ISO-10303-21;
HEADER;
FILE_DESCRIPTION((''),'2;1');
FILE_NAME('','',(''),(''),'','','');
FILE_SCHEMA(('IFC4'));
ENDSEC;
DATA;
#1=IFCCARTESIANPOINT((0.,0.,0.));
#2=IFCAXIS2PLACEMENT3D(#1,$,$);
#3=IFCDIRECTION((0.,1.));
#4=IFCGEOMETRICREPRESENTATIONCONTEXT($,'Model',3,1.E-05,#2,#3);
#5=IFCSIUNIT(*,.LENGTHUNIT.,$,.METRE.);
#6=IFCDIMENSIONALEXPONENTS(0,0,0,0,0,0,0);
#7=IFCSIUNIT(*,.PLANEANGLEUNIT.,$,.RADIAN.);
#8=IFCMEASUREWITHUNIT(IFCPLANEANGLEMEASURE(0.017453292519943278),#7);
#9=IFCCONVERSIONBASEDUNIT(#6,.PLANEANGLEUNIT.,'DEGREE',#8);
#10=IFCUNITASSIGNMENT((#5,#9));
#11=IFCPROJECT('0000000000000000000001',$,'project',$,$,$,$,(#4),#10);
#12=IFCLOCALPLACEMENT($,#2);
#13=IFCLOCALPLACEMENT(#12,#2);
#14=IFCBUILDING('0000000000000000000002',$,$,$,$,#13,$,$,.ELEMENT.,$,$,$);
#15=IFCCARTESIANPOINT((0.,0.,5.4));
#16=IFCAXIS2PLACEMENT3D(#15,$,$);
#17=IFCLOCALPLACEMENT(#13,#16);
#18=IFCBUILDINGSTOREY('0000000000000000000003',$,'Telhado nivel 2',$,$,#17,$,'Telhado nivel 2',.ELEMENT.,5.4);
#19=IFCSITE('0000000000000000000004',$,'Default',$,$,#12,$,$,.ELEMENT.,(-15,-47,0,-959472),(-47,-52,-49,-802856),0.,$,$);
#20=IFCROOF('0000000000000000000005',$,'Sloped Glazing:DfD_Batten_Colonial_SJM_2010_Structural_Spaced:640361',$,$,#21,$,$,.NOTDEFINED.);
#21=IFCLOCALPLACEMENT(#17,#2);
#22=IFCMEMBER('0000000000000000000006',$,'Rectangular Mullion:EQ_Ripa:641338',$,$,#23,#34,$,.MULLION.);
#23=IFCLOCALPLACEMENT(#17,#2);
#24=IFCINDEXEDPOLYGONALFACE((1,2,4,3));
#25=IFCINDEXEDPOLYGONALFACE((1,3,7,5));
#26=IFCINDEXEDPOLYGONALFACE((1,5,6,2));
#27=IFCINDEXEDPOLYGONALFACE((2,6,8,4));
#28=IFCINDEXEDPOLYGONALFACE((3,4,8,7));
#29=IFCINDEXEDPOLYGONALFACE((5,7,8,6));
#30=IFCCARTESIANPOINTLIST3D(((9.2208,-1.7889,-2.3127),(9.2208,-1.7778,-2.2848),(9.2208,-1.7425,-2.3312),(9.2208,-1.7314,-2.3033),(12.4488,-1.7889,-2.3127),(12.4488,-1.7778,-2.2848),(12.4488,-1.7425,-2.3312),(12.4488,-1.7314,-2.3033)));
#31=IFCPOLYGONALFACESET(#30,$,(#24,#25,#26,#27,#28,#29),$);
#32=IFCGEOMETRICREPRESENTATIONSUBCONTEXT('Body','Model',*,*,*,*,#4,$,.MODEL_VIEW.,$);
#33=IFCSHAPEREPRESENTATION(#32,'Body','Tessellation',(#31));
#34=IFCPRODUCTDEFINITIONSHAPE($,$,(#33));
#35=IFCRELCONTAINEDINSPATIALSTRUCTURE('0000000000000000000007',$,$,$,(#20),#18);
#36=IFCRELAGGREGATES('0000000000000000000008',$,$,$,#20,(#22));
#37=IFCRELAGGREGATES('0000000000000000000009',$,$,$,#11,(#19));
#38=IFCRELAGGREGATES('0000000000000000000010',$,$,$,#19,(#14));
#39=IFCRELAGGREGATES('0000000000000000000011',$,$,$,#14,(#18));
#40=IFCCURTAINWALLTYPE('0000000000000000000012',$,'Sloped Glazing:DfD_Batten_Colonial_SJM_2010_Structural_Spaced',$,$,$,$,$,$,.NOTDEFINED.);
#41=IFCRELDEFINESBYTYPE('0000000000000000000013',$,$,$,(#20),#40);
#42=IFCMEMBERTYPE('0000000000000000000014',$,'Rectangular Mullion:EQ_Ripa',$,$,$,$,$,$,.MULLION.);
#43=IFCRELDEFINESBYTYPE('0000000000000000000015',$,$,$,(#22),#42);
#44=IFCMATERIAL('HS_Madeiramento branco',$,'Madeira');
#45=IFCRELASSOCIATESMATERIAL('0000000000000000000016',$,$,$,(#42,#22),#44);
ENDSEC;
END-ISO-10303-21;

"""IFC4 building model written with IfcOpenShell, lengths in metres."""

from ifc_helpers import new_model, entity, si_unit, converted_unit, direction, frame, origin, place, context, subcontext, project, spatial, indexed_curve, outline, extrude, source, transform, mapped, material, type_object, type_shapes, element, aggregate, save


model = new_model("IFC4")

# Units and contexts
model_context = context("Model", 3, precision=1e-05, world=origin(), true_north=direction((0.0, 1.0)))
body_context = subcontext(model_context, "Body", "Model", "MODEL_VIEW")
ifc_project = project(units=[si_unit("LENGTHUNIT", "METRE"), converted_unit("PLANEANGLEUNIT", "DEGREE", entity("IfcPlaneAngleMeasure", 0.017453292519943278), si_unit("PLANEANGLEUNIT", "RADIAN"), dimensions=[0, 0, 0, 0, 0, 0, 0])], contexts=[model_context])

# Site, building, storey
site_placement = place(None, origin())
site = spatial("IfcSite", under=ifc_project, at=site_placement, Name="Default", CompositionType="ELEMENT", RefLatitude=(-15, -47, 0, -959472), RefLongitude=(-47, -52, -49, -802856), RefElevation=0.0)
building_placement = place(site_placement, origin())
building = spatial("IfcBuilding", under=site, at=building_placement, CompositionType="ELEMENT")
storey_placement = place(building_placement, frame((0.0, 0.0, 5.4)))
storey = spatial("IfcBuildingStorey", under=building, at=storey_placement, Name="Telhado nivel 2", LongName="Telhado nivel 2", CompositionType="ELEMENT", Elevation=5.4)

# Roof, member
ifc_material = material(Name="HS_Madeiramento branco", Category="Madeira")
curtain_wall_type_1 = type_object("IfcCurtainWallType", Name="Sloped Glazing:DfD_Batten_Colonial_SJM_2010_Structural_Spaced", PredefinedType="NOTDEFINED")
roof_1_placement = place(storey_placement, frame((0.0, 0.0, -5.4)))
roof_1 = element("IfcRoof", 1, at=roof_1_placement, inside=storey, type_object=curtain_wall_type_1, Name="Sloped Glazing:DfD_Batten_Colonial_SJM_2010_Structural_Spaced:640361", PredefinedType="NOTDEFINED")
member_type_1 = type_object("IfcMemberType", Name="Rectangular Mullion:EQ_Ripa", PredefinedType="MULLION", material=ifc_material)
shared_shape_1 = source(origin(), body_context, "Body", "SweptSolid", [
    extrude(outline(indexed_curve([(-0.025, -0.015), (0.025, -0.015), (0.025, 0.015), (-0.025, 0.015), (-0.025, -0.015)], self_intersect=False)), frame((0.0, 0.0, -3.228), z_axis=(0.0, 0.0, 1.0), x_axis=(-1.0, 0.0, 0.0)), (0.0, 0.0, 1.0), 3.228),
])
type_shapes(member_type_1, [shared_shape_1])
member_1_placement = place(roof_1_placement, frame((12.4488, -1.7602, 3.092), z_axis=(1.0, 0.0, 0.0), x_axis=(0.0, -0.928874, 0.370395)))
member_1 = element("IfcMember", 2, at=member_1_placement, type_object=member_type_1, material=ifc_material, Name="Rectangular Mullion:EQ_Ripa:641338", PredefinedType="MULLION", context=body_context, shape_type="MappedRepresentation", body=[
    mapped(shared_shape_1, transform((0.0, 0.0, 0.0), scale=1.0)),
])
aggregate(roof_1, [member_1])

save(model, "model.ifc")
